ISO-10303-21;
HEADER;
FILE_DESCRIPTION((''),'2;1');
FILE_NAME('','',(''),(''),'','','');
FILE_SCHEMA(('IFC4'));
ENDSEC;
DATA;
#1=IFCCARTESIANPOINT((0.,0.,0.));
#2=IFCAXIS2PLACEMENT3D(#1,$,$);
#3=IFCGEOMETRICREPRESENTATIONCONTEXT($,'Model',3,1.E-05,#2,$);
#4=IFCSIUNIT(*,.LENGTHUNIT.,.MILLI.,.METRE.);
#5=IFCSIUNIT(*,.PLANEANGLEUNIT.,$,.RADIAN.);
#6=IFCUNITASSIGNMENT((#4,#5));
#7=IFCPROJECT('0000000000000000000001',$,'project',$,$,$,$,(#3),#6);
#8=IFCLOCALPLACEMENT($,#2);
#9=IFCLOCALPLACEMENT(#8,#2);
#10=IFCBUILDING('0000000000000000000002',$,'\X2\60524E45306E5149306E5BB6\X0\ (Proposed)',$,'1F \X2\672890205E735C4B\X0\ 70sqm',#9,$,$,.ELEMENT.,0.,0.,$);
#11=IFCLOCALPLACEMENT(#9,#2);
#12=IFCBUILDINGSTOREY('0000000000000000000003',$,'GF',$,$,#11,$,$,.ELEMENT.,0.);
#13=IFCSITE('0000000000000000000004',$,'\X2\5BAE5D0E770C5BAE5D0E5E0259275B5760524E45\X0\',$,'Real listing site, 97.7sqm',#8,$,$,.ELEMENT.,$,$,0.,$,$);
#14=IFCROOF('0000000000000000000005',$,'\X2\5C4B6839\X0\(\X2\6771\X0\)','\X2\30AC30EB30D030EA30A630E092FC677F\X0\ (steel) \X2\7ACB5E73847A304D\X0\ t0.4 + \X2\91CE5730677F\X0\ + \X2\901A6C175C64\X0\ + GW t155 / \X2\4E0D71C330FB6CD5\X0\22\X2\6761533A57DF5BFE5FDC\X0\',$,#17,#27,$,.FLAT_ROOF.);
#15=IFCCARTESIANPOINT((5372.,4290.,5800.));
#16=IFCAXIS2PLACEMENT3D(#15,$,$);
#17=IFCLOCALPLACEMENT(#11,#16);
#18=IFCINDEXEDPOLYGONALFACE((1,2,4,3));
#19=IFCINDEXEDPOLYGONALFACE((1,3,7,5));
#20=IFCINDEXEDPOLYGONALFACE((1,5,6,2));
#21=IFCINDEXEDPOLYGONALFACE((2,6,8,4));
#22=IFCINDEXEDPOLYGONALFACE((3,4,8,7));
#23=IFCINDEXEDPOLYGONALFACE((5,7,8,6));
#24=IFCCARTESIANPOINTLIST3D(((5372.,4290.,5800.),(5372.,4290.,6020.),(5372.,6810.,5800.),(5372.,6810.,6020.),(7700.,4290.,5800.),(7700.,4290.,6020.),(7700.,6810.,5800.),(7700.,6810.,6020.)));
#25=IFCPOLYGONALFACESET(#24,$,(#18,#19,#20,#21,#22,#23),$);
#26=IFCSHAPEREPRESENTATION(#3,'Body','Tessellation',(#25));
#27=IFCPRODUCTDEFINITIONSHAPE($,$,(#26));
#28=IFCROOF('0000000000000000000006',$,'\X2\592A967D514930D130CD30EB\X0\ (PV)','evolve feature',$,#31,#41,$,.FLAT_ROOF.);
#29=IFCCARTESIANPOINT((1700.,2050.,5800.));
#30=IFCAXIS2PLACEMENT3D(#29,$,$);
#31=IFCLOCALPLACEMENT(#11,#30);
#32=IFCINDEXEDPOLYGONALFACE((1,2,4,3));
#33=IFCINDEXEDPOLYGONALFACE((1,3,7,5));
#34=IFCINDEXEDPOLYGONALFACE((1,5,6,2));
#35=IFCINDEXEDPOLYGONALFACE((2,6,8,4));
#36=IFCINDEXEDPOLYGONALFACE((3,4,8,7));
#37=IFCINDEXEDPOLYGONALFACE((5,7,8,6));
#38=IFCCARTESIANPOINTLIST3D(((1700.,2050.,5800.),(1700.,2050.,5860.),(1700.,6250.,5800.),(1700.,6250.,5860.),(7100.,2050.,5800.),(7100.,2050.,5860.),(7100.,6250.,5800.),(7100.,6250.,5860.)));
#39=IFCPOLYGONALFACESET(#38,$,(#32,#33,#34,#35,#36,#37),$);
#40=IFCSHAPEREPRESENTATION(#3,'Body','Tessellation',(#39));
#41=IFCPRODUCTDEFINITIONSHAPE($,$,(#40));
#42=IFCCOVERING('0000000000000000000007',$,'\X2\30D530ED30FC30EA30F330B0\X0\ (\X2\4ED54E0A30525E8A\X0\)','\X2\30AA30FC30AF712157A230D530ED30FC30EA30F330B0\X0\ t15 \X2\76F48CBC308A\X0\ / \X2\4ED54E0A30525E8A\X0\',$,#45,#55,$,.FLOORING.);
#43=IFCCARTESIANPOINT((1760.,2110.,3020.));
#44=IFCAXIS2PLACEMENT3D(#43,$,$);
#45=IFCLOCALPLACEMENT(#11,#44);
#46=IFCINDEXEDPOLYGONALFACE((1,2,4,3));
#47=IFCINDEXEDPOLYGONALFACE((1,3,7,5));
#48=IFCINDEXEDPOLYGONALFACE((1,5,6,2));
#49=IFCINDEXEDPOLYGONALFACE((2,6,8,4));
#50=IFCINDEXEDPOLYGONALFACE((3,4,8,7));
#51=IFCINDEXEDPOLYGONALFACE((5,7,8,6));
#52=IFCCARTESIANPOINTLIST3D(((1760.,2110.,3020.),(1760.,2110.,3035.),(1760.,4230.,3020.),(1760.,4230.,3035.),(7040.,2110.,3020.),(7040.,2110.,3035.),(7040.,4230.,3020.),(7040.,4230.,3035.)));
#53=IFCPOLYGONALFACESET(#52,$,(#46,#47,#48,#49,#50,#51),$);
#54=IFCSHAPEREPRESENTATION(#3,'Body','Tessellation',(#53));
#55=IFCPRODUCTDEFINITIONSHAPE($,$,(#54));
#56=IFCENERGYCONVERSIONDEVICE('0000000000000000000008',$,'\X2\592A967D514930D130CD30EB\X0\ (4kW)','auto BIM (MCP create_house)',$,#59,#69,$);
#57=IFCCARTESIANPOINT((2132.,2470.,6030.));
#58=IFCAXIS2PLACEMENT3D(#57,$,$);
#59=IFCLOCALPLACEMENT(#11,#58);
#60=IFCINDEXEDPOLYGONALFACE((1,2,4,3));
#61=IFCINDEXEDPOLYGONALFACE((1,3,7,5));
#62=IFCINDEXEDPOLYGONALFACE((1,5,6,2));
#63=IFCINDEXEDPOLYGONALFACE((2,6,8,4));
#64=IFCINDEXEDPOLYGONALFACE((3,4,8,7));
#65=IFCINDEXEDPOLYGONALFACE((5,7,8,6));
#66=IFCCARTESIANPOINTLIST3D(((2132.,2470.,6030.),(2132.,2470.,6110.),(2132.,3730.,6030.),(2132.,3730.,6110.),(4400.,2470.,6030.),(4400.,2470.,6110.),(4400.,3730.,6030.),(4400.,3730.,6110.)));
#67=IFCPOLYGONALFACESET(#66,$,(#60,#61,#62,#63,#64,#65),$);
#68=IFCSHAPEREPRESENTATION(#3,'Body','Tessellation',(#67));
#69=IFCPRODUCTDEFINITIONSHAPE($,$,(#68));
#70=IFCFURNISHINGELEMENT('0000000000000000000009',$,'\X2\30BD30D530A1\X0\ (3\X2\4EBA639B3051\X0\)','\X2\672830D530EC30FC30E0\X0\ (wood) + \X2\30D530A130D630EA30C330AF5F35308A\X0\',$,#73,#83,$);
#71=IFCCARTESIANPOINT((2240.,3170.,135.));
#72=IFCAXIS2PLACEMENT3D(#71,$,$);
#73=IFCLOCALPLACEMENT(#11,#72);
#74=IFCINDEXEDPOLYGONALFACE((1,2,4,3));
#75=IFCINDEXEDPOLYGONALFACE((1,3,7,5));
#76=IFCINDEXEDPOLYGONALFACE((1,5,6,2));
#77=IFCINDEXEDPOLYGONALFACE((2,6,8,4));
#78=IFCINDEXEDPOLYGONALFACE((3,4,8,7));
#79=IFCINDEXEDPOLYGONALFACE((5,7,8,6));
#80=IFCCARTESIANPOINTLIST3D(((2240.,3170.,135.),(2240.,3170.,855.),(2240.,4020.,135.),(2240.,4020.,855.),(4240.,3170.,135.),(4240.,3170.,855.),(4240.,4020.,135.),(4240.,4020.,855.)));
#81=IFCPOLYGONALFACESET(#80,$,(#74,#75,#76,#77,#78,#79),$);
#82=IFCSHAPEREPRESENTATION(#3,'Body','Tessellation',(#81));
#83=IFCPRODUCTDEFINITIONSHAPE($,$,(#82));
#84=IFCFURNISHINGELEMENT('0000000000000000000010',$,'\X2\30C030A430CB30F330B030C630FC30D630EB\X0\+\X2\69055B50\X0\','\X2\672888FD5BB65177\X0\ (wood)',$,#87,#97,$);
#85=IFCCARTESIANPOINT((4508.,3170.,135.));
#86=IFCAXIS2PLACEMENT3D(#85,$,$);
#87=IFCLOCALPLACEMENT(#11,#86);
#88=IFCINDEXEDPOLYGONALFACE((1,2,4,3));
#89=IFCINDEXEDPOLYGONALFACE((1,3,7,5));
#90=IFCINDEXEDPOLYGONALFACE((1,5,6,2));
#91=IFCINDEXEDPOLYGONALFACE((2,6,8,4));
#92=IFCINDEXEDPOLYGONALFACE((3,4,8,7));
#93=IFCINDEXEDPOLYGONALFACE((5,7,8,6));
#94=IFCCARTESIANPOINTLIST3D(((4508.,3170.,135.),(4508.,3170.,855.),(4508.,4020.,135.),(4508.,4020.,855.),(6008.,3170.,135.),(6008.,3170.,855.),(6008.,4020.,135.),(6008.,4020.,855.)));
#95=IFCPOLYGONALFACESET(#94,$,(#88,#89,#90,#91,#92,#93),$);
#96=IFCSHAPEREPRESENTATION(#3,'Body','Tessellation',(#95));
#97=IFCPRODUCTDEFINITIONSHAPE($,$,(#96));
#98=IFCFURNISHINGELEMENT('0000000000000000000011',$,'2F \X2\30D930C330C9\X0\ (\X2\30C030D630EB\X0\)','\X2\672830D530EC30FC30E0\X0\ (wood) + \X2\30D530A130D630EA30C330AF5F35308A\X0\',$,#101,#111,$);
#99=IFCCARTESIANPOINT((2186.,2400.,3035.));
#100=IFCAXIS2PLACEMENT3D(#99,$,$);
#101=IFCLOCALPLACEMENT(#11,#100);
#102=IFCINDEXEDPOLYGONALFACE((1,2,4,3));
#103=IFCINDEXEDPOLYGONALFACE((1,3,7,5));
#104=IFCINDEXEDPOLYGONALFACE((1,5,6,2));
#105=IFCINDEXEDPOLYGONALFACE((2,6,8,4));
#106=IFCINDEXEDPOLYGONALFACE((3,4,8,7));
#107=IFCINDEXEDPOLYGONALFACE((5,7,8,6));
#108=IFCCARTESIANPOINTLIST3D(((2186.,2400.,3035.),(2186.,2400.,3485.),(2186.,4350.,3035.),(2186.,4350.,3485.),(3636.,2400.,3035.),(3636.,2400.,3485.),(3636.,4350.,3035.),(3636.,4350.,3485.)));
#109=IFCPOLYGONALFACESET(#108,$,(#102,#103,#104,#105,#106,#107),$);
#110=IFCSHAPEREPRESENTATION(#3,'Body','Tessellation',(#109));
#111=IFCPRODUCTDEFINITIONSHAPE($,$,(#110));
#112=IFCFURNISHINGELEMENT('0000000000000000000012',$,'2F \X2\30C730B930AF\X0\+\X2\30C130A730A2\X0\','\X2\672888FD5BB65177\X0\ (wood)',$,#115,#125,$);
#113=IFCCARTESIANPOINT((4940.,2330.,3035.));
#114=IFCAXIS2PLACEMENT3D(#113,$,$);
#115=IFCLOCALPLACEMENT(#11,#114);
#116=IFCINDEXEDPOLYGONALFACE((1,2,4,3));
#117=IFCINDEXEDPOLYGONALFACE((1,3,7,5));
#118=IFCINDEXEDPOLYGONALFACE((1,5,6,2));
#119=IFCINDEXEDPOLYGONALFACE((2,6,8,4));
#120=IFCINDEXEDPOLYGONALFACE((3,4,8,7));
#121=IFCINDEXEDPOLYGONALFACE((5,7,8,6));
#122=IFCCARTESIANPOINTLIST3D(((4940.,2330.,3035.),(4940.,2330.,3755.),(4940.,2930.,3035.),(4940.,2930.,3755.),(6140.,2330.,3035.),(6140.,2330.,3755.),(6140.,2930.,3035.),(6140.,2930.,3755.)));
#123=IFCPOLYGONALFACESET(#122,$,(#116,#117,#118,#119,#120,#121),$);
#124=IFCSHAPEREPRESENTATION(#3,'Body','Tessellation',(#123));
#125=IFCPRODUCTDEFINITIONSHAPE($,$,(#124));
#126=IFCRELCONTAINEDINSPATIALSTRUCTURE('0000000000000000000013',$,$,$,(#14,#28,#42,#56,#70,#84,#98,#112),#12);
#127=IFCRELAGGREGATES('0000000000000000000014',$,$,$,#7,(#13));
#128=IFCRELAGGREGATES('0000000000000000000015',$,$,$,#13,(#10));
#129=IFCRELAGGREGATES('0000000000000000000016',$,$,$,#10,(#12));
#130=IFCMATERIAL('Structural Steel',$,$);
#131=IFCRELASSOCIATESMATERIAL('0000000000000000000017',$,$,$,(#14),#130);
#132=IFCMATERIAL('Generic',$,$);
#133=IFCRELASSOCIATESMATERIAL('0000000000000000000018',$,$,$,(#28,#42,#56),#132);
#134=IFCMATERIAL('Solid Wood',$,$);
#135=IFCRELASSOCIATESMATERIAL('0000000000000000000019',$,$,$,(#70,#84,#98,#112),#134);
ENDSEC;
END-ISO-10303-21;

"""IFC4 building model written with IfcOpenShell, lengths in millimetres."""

from ifc_helpers import new_model, si_unit, frame, frame_2d, origin, place, context, project, spatial, rectangle, extrude, material, element, save


model = new_model("IFC4")

# Units and contexts
model_context = context("Model", 3, precision=1e-05, world=origin())
ifc_project = project(units=[si_unit("LENGTHUNIT", "METRE", prefix="MILLI"), si_unit("PLANEANGLEUNIT", "RADIAN")], contexts=[model_context])

# Site, building, storey
site_placement = place(None, origin())
site = spatial("IfcSite", under=ifc_project, at=site_placement, Name="宮崎県宮崎市大字恒久", ObjectType="Real listing site, 97.7sqm", CompositionType="ELEMENT", RefElevation=0.0)
building_placement = place(site_placement, origin())
building = spatial("IfcBuilding", under=site, at=building_placement, Name="恒久の光の家 (Proposed)", ObjectType="1F 木造平屋 70sqm", CompositionType="ELEMENT", ElevationOfRefHeight=0.0, ElevationOfTerrain=0.0)
storey_placement = place(building_placement, origin())
storey = spatial("IfcBuildingStorey", under=building, at=storey_placement, Name="GF", CompositionType="ELEMENT", Elevation=0.0)

# Shared definitions
ifc_material_1 = material(Name="Solid Wood")

# Roofs
ifc_material_2 = material(Name="Structural Steel")
roof_1_placement = place(storey_placement, frame((5372.0, 4290.0, 5800.0)))
element("IfcRoof", 1, at=roof_1_placement, inside=storey, material=ifc_material_2, Name="屋根(東)", Description="ガルバリウム鋼板 (steel) 立平葺き t0.4 + 野地板 + 通気層 + GW t155 / 不燃・法22条区域対応", PredefinedType="FLAT_ROOF", context=model_context, shape_type="SweptSolid", body=[
    extrude(rectangle(XDim=2328.0, YDim=2520.0, at=frame_2d((1164.0, 1260.0))), frame((5372.0, 4290.0, 5800.0)), (0.0, 0.0, 1.0), 220.0),
])
ifc_material_3 = material(Name="Generic")
roof_2_placement = place(storey_placement, frame((1700.0, 2050.0, 5800.0)))
element("IfcRoof", 2, at=roof_2_placement, inside=storey, material=ifc_material_3, Name="太陽光パネル (PV)", Description="evolve feature", PredefinedType="FLAT_ROOF", context=model_context, shape_type="SweptSolid", body=[
    extrude(rectangle(XDim=5400.0, YDim=4200.0, at=frame_2d((2700.0, 2100.0))), frame((1700.0, 2050.0, 5800.0)), (0.0, 0.0, 1.0), 60.0),
])

# Covering
covering_placement = place(storey_placement, frame((1760.0, 2110.0, 3020.0)))
element("IfcCovering", 3, at=covering_placement, inside=storey, material=ifc_material_3, Name="フローリング (仕上げ床)", Description="オーク無垢フローリング t15 直貼り / 仕上げ床", PredefinedType="FLOORING", context=model_context, shape_type="SweptSolid", body=[
    extrude(rectangle(XDim=5280.0, YDim=2120.0, at=frame_2d((2640.0, 1060.0))), frame((1760.0, 2110.0, 3020.0)), (0.0, 0.0, 1.0), 15.0),
])

# Energy conversion device
energy_conversion_device_placement = place(storey_placement, frame((2132.0, 2470.0, 6030.0)))
element("IfcEnergyConversionDevice", 4, at=energy_conversion_device_placement, inside=storey, material=ifc_material_3, Name="太陽光パネル (4kW)", Description="auto BIM (MCP create_house)", context=model_context, shape_type="SweptSolid", body=[
    extrude(rectangle(XDim=2268.0, YDim=1260.0, at=frame_2d((1134.0, 630.0))), frame((2132.0, 2470.0, 6030.0)), (0.0, 0.0, 1.0), 80.0),
])

# Furnishing elements
furnishing_1_placement = place(storey_placement, frame((2240.0, 3170.0, 135.0)))
element("IfcFurnishingElement", 5, at=furnishing_1_placement, inside=storey, material=ifc_material_1, Name="ソファ (3人掛け)", Description="木フレーム (wood) + ファブリック張り", context=model_context, shape_type="SweptSolid", body=[
    extrude(rectangle(XDim=2000.0, YDim=850.0, at=frame_2d((1000.0, 425.0))), frame((2240.0, 3170.0, 135.0)), (0.0, 0.0, 1.0), 720.0),
])
furnishing_2_placement = place(storey_placement, frame((4508.0, 3170.0, 135.0)))
element("IfcFurnishingElement", 6, at=furnishing_2_placement, inside=storey, material=ifc_material_1, Name="ダイニングテーブル+椅子", Description="木製家具 (wood)", context=model_context, shape_type="SweptSolid", body=[
    extrude(rectangle(XDim=1500.0, YDim=850.0, at=frame_2d((750.0, 425.0))), frame((4508.0, 3170.0, 135.0)), (0.0, 0.0, 1.0), 720.0),
])
furnishing_3_placement = place(storey_placement, frame((2186.0, 2400.0, 3035.0)))
element("IfcFurnishingElement", 7, at=furnishing_3_placement, inside=storey, material=ifc_material_1, Name="2F ベッド (ダブル)", Description="木フレーム (wood) + ファブリック張り", context=model_context, shape_type="SweptSolid", body=[
    extrude(rectangle(XDim=1450.0, YDim=1950.0, at=frame_2d((725.0, 975.0))), frame((2186.0, 2400.0, 3035.0)), (0.0, 0.0, 1.0), 450.0),
])
furnishing_4_placement = place(storey_placement, frame((4940.0, 2330.0, 3035.0)))
element("IfcFurnishingElement", 8, at=furnishing_4_placement, inside=storey, material=ifc_material_1, Name="2F デスク+チェア", Description="木製家具 (wood)", context=model_context, shape_type="SweptSolid", body=[
    extrude(rectangle(XDim=1200.0, YDim=600.0, at=frame_2d((600.0, 300.0))), frame((4940.0, 2330.0, 3035.0)), (0.0, 0.0, 1.0), 720.0),
])

save(model, "model.ifc")
